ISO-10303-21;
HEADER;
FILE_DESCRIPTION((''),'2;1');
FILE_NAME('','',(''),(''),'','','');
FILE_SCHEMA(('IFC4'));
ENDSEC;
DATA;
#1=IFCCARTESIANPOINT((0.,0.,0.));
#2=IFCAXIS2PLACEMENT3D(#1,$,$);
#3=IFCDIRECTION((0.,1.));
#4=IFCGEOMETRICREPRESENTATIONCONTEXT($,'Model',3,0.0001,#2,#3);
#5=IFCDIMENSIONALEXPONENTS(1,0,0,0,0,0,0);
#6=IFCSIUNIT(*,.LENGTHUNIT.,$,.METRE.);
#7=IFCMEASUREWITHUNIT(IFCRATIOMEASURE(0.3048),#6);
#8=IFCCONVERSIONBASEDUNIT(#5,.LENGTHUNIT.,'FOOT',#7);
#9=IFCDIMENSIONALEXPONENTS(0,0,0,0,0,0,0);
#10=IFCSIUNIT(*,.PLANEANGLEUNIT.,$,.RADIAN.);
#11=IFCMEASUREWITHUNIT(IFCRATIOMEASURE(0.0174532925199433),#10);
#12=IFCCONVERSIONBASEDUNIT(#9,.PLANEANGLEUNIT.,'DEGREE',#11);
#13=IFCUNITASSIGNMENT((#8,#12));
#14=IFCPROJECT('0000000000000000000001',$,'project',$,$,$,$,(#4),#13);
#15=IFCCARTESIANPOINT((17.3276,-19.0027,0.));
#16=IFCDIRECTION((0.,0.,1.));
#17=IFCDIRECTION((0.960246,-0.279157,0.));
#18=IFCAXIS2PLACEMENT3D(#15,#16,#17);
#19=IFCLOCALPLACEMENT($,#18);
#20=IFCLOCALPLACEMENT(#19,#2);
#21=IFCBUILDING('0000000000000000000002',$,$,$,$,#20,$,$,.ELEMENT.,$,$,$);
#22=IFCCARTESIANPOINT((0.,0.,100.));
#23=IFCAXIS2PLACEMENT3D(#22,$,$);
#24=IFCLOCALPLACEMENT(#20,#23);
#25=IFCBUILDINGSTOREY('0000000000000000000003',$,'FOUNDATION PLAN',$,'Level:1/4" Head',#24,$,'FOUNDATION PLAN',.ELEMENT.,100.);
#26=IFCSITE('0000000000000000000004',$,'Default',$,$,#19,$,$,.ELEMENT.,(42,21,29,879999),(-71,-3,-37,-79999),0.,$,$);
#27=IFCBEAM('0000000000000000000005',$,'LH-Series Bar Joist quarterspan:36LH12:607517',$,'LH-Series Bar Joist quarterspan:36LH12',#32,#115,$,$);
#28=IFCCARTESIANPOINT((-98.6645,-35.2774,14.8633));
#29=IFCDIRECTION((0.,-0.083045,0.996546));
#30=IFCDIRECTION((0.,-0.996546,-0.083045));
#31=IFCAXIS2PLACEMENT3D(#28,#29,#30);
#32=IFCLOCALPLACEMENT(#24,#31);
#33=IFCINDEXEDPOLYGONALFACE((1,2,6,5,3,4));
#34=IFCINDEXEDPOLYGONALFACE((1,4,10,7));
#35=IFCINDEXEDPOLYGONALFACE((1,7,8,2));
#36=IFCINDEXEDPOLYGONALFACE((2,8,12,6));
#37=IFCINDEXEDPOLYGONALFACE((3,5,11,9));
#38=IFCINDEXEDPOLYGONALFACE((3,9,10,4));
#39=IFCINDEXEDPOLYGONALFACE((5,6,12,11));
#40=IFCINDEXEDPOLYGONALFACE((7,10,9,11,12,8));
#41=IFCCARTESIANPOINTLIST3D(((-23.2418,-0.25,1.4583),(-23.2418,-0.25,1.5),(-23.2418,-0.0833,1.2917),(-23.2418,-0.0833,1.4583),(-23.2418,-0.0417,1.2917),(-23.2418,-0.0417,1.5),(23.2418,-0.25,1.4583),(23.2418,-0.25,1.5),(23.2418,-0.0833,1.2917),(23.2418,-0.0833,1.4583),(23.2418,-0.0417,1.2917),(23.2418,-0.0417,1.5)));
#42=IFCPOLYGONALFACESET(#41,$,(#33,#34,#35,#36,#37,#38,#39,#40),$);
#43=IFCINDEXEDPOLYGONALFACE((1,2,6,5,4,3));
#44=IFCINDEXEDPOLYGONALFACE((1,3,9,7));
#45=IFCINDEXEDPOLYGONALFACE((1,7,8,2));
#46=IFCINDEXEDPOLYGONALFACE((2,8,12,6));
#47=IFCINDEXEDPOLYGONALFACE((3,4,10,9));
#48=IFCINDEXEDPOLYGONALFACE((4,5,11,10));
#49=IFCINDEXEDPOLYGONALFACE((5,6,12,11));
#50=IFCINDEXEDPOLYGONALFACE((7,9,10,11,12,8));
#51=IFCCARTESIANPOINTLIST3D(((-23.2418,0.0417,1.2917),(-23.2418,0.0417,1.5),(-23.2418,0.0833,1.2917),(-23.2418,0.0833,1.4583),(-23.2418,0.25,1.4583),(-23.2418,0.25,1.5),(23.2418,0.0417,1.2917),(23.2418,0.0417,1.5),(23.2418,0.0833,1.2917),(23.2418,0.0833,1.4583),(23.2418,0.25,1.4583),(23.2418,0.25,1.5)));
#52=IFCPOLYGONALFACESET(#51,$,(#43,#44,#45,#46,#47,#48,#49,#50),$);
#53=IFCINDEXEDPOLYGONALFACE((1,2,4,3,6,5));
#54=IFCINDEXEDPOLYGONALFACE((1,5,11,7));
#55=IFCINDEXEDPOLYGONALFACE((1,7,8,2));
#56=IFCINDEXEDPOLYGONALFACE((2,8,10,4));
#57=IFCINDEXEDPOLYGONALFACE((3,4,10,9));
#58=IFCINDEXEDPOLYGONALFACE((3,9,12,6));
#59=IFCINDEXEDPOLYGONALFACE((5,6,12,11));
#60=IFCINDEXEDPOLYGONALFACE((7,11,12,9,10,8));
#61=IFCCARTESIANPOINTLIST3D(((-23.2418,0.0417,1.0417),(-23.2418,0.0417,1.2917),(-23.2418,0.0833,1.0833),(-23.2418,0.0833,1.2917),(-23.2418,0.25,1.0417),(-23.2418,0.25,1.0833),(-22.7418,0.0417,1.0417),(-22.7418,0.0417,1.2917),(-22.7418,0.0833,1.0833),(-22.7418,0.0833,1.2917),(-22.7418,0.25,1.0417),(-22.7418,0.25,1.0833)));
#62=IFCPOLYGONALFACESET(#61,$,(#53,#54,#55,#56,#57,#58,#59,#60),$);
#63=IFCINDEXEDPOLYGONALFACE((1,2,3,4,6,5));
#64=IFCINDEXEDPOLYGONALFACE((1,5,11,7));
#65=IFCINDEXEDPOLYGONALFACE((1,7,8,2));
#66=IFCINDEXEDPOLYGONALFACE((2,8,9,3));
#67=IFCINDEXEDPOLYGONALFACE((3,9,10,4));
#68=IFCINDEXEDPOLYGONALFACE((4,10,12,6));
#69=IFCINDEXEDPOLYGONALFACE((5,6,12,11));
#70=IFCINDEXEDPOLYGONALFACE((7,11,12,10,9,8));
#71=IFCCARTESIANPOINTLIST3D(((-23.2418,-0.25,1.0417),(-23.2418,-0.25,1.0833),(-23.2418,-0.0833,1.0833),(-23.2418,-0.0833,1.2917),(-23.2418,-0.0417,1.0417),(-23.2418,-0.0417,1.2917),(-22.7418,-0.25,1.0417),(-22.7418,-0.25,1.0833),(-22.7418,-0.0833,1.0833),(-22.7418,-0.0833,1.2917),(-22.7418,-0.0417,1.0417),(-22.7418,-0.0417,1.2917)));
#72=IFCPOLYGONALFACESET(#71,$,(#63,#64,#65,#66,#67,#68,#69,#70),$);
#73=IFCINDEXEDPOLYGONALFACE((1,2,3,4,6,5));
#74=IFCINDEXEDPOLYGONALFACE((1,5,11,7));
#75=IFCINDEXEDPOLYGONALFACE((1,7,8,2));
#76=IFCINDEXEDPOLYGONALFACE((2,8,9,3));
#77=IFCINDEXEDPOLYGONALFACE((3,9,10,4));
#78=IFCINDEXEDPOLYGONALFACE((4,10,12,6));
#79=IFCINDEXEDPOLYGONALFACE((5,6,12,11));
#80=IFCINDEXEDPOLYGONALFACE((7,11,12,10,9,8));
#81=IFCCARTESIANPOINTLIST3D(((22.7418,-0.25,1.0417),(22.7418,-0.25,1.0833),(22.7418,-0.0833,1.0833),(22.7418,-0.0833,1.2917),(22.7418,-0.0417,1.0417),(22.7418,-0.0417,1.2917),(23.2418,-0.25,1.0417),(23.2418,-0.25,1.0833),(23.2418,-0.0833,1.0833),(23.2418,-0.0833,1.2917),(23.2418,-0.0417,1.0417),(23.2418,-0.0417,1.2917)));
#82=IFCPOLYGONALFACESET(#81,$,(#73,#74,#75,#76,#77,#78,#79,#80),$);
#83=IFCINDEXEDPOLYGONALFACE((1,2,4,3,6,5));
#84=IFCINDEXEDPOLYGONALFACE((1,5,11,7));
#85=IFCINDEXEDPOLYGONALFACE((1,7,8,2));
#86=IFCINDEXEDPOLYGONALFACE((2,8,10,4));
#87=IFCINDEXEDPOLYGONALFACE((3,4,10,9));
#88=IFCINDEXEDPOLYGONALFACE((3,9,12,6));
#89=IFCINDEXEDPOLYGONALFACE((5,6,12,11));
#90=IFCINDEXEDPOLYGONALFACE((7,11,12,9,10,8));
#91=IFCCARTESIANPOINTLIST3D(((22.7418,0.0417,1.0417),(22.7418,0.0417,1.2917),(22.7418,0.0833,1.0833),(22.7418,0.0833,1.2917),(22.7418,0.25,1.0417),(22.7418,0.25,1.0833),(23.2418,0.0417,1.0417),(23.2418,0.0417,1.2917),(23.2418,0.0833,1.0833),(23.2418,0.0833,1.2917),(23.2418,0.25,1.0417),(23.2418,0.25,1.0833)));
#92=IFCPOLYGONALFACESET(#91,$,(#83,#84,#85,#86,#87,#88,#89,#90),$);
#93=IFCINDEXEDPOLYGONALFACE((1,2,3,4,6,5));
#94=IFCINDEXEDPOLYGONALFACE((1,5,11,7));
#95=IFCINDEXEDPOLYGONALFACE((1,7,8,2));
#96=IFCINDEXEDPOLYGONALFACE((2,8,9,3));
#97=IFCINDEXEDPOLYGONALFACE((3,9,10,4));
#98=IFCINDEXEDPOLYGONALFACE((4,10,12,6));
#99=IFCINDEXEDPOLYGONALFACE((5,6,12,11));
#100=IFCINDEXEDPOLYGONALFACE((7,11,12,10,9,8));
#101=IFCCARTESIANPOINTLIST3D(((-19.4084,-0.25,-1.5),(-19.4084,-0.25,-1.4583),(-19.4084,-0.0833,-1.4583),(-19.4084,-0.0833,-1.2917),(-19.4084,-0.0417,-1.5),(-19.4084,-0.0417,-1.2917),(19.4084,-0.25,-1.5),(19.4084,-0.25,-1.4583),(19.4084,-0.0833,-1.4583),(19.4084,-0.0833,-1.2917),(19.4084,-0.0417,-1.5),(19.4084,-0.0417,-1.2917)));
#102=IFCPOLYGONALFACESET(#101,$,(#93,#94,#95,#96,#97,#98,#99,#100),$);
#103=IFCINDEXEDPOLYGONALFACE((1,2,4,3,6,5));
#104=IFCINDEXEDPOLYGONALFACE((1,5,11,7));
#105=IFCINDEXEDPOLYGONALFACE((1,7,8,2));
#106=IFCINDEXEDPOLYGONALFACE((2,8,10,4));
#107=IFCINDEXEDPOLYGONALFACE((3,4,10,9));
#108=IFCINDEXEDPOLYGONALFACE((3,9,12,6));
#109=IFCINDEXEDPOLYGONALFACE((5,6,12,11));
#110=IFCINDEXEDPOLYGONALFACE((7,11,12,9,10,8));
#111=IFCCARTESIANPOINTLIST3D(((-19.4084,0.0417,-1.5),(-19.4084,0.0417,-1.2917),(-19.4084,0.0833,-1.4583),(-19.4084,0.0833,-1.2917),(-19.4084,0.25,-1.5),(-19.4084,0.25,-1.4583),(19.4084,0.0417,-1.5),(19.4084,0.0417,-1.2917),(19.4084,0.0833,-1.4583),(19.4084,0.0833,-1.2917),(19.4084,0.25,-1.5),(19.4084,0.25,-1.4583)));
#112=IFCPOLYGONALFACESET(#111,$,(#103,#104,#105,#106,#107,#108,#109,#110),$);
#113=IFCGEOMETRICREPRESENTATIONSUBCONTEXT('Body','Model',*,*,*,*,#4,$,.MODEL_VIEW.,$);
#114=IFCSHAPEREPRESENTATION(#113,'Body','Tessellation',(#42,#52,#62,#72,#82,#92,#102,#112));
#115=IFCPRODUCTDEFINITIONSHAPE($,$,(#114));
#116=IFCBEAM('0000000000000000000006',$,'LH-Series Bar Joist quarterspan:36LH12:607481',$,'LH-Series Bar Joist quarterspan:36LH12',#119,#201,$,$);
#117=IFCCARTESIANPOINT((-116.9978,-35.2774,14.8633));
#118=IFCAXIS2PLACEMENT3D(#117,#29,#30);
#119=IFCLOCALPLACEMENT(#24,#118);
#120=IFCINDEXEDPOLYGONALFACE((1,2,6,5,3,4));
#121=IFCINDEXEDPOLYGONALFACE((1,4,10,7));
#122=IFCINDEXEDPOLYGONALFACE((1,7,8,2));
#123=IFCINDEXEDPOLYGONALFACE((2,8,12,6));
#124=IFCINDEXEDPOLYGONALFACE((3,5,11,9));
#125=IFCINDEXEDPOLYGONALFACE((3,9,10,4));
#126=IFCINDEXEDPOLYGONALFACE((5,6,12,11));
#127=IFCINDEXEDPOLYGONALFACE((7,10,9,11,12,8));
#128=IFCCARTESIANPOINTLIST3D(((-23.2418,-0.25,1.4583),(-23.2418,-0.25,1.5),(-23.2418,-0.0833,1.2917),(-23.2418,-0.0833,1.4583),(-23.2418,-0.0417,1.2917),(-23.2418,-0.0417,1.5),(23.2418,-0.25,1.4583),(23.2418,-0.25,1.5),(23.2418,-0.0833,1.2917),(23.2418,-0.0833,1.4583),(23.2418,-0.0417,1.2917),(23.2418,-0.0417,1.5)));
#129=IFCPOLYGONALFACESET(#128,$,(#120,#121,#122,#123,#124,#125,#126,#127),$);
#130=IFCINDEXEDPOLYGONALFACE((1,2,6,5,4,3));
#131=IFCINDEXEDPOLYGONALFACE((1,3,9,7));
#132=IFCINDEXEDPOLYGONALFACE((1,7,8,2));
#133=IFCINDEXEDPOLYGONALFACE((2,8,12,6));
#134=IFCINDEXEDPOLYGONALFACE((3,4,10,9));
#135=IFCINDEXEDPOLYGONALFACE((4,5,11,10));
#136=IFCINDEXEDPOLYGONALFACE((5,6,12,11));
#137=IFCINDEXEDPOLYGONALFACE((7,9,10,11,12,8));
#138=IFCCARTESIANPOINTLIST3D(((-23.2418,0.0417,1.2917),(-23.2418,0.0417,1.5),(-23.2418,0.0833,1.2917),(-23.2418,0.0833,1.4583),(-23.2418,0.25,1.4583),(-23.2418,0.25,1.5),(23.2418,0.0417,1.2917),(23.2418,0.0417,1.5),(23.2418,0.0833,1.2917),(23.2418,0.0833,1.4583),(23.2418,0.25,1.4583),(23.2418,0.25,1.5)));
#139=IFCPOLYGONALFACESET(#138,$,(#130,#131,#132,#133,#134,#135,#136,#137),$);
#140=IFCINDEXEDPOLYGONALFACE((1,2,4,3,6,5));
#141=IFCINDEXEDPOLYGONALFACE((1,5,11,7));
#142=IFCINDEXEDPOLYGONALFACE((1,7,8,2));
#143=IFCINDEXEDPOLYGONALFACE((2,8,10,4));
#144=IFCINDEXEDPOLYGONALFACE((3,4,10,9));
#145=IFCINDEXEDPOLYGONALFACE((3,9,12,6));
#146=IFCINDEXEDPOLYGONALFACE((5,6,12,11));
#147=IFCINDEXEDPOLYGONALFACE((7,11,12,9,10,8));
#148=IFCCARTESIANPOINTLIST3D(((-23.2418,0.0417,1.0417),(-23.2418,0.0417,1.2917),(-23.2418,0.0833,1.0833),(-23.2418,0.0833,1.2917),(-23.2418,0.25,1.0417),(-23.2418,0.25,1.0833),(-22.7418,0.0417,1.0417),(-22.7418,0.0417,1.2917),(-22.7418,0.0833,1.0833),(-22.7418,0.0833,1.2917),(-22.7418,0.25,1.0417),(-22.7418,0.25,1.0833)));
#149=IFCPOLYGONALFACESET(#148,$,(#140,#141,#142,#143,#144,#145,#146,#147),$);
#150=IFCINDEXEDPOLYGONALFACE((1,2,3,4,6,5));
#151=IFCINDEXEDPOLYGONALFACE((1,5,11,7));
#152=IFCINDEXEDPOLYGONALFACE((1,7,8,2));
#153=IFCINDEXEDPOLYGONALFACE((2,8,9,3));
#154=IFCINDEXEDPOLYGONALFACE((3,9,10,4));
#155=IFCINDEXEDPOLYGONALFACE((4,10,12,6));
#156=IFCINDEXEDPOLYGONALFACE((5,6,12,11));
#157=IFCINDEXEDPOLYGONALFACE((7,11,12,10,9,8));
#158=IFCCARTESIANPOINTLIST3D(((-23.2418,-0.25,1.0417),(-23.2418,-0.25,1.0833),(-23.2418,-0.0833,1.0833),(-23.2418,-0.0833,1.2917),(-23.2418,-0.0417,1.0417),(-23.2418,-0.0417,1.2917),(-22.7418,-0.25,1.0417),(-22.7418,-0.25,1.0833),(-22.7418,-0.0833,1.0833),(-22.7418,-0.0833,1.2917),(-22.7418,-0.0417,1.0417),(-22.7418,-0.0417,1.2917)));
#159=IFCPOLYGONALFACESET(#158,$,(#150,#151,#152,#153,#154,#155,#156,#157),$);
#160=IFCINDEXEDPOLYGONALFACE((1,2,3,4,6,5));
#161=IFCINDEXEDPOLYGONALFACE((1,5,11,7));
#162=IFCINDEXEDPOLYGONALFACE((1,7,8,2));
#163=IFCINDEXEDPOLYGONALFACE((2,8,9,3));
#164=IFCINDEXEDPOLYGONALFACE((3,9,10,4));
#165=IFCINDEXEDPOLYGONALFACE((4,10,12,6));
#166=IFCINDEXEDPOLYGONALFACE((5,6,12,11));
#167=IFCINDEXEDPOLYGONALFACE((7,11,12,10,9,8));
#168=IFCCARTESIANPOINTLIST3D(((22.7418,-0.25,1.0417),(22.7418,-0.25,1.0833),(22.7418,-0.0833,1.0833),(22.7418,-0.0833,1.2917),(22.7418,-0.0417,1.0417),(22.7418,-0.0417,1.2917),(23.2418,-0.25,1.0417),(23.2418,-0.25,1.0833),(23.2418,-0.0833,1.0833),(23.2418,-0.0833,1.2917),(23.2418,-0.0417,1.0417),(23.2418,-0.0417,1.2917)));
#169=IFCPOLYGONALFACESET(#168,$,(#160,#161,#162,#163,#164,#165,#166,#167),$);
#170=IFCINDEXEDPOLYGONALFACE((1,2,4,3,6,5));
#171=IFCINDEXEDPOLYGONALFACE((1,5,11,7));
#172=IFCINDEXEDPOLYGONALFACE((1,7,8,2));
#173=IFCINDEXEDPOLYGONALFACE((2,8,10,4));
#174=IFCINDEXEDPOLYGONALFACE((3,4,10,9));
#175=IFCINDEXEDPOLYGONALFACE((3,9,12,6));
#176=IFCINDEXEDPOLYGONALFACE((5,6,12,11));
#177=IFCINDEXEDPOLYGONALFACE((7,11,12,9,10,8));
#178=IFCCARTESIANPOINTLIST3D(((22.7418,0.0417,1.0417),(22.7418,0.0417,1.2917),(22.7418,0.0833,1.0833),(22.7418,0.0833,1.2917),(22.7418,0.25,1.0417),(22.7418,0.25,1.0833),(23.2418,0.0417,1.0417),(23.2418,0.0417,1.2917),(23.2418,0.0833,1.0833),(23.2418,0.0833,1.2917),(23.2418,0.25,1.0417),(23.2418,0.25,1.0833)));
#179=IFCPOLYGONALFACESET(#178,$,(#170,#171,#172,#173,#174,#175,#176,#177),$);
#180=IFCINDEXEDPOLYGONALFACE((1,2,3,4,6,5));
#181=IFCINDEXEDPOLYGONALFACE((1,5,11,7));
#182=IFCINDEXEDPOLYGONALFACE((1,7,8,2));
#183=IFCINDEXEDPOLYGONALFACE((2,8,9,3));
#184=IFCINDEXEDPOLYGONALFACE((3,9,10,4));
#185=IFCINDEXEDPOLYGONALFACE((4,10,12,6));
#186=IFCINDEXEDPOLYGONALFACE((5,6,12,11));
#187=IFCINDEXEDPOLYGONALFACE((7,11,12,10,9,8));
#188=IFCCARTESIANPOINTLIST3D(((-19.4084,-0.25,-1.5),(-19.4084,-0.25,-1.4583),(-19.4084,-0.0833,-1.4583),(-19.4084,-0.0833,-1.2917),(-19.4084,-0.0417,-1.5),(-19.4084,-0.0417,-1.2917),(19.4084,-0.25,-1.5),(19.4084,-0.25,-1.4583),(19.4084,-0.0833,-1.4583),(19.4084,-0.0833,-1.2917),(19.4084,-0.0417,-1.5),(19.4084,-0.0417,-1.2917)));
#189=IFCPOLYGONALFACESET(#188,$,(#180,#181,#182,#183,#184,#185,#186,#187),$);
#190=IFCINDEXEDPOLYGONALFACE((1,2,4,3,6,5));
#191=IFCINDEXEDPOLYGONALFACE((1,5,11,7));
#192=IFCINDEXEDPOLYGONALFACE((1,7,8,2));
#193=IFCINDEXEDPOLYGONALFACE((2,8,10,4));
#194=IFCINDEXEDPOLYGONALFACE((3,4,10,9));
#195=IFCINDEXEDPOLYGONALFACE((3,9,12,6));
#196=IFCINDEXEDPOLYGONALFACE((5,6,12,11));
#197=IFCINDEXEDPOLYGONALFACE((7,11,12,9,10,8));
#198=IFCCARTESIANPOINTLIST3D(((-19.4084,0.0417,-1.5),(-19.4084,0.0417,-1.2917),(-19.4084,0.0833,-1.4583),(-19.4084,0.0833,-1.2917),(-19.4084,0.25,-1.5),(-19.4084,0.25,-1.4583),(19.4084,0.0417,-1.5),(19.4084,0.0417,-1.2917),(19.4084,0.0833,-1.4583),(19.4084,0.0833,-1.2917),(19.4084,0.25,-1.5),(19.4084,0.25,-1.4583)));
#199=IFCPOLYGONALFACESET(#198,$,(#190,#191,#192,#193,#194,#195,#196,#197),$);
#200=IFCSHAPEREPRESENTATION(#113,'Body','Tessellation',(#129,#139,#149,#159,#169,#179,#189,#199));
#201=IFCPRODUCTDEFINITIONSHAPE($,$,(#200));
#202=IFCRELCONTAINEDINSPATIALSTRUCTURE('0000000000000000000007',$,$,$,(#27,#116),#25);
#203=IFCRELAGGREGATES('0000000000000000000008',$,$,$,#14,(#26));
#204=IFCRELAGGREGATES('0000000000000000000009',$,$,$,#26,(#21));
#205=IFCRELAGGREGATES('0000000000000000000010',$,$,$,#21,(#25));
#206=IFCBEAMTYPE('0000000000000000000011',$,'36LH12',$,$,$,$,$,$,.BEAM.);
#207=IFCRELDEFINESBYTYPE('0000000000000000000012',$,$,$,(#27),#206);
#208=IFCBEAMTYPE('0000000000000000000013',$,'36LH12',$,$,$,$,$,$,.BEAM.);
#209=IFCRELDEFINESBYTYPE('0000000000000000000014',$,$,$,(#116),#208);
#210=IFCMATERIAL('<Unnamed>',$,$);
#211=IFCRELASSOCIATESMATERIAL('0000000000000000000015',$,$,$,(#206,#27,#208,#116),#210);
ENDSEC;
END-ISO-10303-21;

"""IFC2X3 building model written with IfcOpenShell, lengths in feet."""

from ifc_helpers import new_model, entity, si_unit, converted_unit, direction, frame, origin, place, context, subcontext, project, spatial, polyline, outline, extrude, source, transform, mapped, material, type_object, type_shapes, element, save


model = new_model("IFC2X3")

# Units and contexts
model_context = context("Model", 3, precision=0.0001, world=origin(), true_north=direction((0.0, 1.0)))
body_context = subcontext(model_context, "Body", "Model", "MODEL_VIEW")
ifc_project = project(units=[converted_unit("LENGTHUNIT", "FOOT", entity("IfcRatioMeasure", 0.3048), si_unit("LENGTHUNIT", "METRE"), dimensions=[1, 0, 0, 0, 0, 0, 0]), converted_unit("PLANEANGLEUNIT", "DEGREE", entity("IfcRatioMeasure", 0.0174532925199433), si_unit("PLANEANGLEUNIT", "RADIAN"), dimensions=[0, 0, 0, 0, 0, 0, 0])], contexts=[model_context])

# Site, building, storey
site_placement = place(None, frame((17.3276, -19.0027, 0.0), z_axis=(0.0, 0.0, 1.0), x_axis=(0.960246, -0.279157, 0.0)))
site = spatial("IfcSite", under=ifc_project, at=site_placement, Name="Default", CompositionType="ELEMENT", RefLatitude=(42, 21, 29, 879999), RefLongitude=(-71, -3, -37, -79999), RefElevation=0.0)
building_placement = place(site_placement, origin())
building = spatial("IfcBuilding", under=site, at=building_placement, CompositionType="ELEMENT")
storey_placement = place(building_placement, frame((0.0, 0.0, 100.0)))
storey = spatial("IfcBuildingStorey", under=building, at=storey_placement, Name="FOUNDATION PLAN", ObjectType="Level:1/4\" Head", LongName="FOUNDATION PLAN", CompositionType="ELEMENT", Elevation=100.0)

# Shared definitions
ifc_material_1 = material(Name="<Unnamed>")

# Beams
beam_type_1 = type_object("IfcBeamType", Name="36LH12", PredefinedType="BEAM", material=ifc_material_1)
shared_shape_1 = source(origin(), body_context, "Body", "SweptSolid", [
    extrude(outline(polyline([(-0.0833, -0.125), (-0.0417, -0.125), (-0.0417, 0.0417), (0.125, 0.0417), (0.125, 0.0833), (-0.0833, 0.0833), (-0.0833, -0.125)])), frame((-23.2418, -0.125, 1.4167), z_axis=(1.0, 0.0, 0.0), x_axis=(0.0, 0.0, -1.0)), (0.0, 0.0, 1.0), 46.4835),
    extrude(outline(polyline([(-0.0833, -0.0833), (0.125, -0.0833), (0.125, -0.0417), (-0.0417, -0.0417), (-0.0417, 0.125), (-0.0833, 0.125), (-0.0833, -0.0833)])), frame((-23.2418, 0.125, 1.4167), z_axis=(1.0, 0.0, 0.0), x_axis=(0.0, 0.0, -1.0)), (0.0, 0.0, 1.0), 46.4835),
    extrude(outline(polyline([(-0.1528, -0.0833), (0.0972, -0.0833), (0.0972, 0.125), (0.0556, 0.125), (0.0556, -0.0417), (-0.1528, -0.0417), (-0.1528, -0.0833)])), frame((-23.2418, 0.125, 1.1389), z_axis=(1.0, 0.0, 0.0), x_axis=(0.0, 0.0, -1.0)), (0.0, 0.0, 1.0), 0.5),
    extrude(outline(polyline([(0.0556, -0.125), (0.0972, -0.125), (0.0972, 0.0833), (-0.1528, 0.0833), (-0.1528, 0.0417), (0.0556, 0.0417), (0.0556, -0.125)])), frame((-23.2418, -0.125, 1.1389), z_axis=(1.0, 0.0, 0.0), x_axis=(0.0, 0.0, -1.0)), (0.0, 0.0, 1.0), 0.5),
    extrude(outline(polyline([(0.0556, -0.125), (0.0972, -0.125), (0.0972, 0.0833), (-0.1528, 0.0833), (-0.1528, 0.0417), (0.0556, 0.0417), (0.0556, -0.125)])), frame((22.7418, -0.125, 1.1389), z_axis=(1.0, 0.0, 0.0), x_axis=(0.0, 0.0, -1.0)), (0.0, 0.0, 1.0), 0.5),
    extrude(outline(polyline([(-0.1528, -0.0833), (0.0972, -0.0833), (0.0972, 0.125), (0.0556, 0.125), (0.0556, -0.0417), (-0.1528, -0.0417), (-0.1528, -0.0833)])), frame((22.7418, 0.125, 1.1389), z_axis=(1.0, 0.0, 0.0), x_axis=(0.0, 0.0, -1.0)), (0.0, 0.0, 1.0), 0.5),
    extrude(outline(polyline([(0.0417, -0.125), (0.0833, -0.125), (0.0833, 0.0833), (-0.125, 0.0833), (-0.125, 0.0417), (0.0417, 0.0417), (0.0417, -0.125)])), frame((-19.4084, -0.125, -1.4167), z_axis=(1.0, 0.0, 0.0), x_axis=(0.0, 0.0, -1.0)), (0.0, 0.0, 1.0), 38.8169),
    extrude(outline(polyline([(-0.125, -0.0833), (0.0833, -0.0833), (0.0833, 0.125), (0.0417, 0.125), (0.0417, -0.0417), (-0.125, -0.0417), (-0.125, -0.0833)])), frame((-19.4084, 0.125, -1.4167), z_axis=(1.0, 0.0, 0.0), x_axis=(0.0, 0.0, -1.0)), (0.0, 0.0, 1.0), 38.8169),
])
type_shapes(beam_type_1, [shared_shape_1])
for number, where, z_axis, x_axis, name in (
    (1, (-98.6645, -35.2774, 14.8633), (0.0, -0.083045, 0.996546), (0.0, -0.996546, -0.083045), "LH-Series Bar Joist quarterspan:36LH12:607517"),
):
    element("IfcBeam", number, at=place(storey_placement, frame(where, z_axis=z_axis, x_axis=x_axis)), inside=storey, type_object=beam_type_1, material=ifc_material_1, Name=name, ObjectType="LH-Series Bar Joist quarterspan:36LH12", context=body_context, shape_type="MappedRepresentation", body=[
        mapped(shared_shape_1, transform((0.0, 0.0, 0.0), scale=1.0)),
    ])
beam_type_2 = type_object("IfcBeamType", Name="36LH12", PredefinedType="BEAM", material=ifc_material_1)
shared_shape_2 = source(origin(), body_context, "Body", "SweptSolid", [
    extrude(outline(polyline([(-0.0833, -0.125), (-0.0417, -0.125), (-0.0417, 0.0417), (0.125, 0.0417), (0.125, 0.0833), (-0.0833, 0.0833), (-0.0833, -0.125)])), frame((-23.2418, -0.125, 1.4167), z_axis=(1.0, 0.0, 0.0), x_axis=(0.0, 0.0, -1.0)), (0.0, 0.0, 1.0), 46.4835),
    extrude(outline(polyline([(-0.0833, -0.0833), (0.125, -0.0833), (0.125, -0.0417), (-0.0417, -0.0417), (-0.0417, 0.125), (-0.0833, 0.125), (-0.0833, -0.0833)])), frame((-23.2418, 0.125, 1.4167), z_axis=(1.0, 0.0, 0.0), x_axis=(0.0, 0.0, -1.0)), (0.0, 0.0, 1.0), 46.4835),
    extrude(outline(polyline([(-0.1528, -0.0833), (0.0972, -0.0833), (0.0972, 0.125), (0.0556, 0.125), (0.0556, -0.0417), (-0.1528, -0.0417), (-0.1528, -0.0833)])), frame((-23.2418, 0.125, 1.1389), z_axis=(1.0, 0.0, 0.0), x_axis=(0.0, 0.0, -1.0)), (0.0, 0.0, 1.0), 0.5),
    extrude(outline(polyline([(0.0556, -0.125), (0.0972, -0.125), (0.0972, 0.0833), (-0.1528, 0.0833), (-0.1528, 0.0417), (0.0556, 0.0417), (0.0556, -0.125)])), frame((-23.2418, -0.125, 1.1389), z_axis=(1.0, 0.0, 0.0), x_axis=(0.0, 0.0, -1.0)), (0.0, 0.0, 1.0), 0.5),
    extrude(outline(polyline([(0.0556, -0.125), (0.0972, -0.125), (0.0972, 0.0833), (-0.1528, 0.0833), (-0.1528, 0.0417), (0.0556, 0.0417), (0.0556, -0.125)])), frame((22.7418, -0.125, 1.1389), z_axis=(1.0, 0.0, 0.0), x_axis=(0.0, 0.0, -1.0)), (0.0, 0.0, 1.0), 0.5),
    extrude(outline(polyline([(-0.1528, -0.0833), (0.0972, -0.0833), (0.0972, 0.125), (0.0556, 0.125), (0.0556, -0.0417), (-0.1528, -0.0417), (-0.1528, -0.0833)])), frame((22.7418, 0.125, 1.1389), z_axis=(1.0, 0.0, 0.0), x_axis=(0.0, 0.0, -1.0)), (0.0, 0.0, 1.0), 0.5),
    extrude(outline(polyline([(0.0417, -0.125), (0.0833, -0.125), (0.0833, 0.0833), (-0.125, 0.0833), (-0.125, 0.0417), (0.0417, 0.0417), (0.0417, -0.125)])), frame((-19.4084, -0.125, -1.4167), z_axis=(1.0, 0.0, 0.0), x_axis=(0.0, 0.0, -1.0)), (0.0, 0.0, 1.0), 38.8169),
    extrude(outline(polyline([(-0.125, -0.0833), (0.0833, -0.0833), (0.0833, 0.125), (0.0417, 0.125), (0.0417, -0.0417), (-0.125, -0.0417), (-0.125, -0.0833)])), frame((-19.4084, 0.125, -1.4167), z_axis=(1.0, 0.0, 0.0), x_axis=(0.0, 0.0, -1.0)), (0.0, 0.0, 1.0), 38.8169),
])
type_shapes(beam_type_2, [shared_shape_2])
beam_1_placement = place(storey_placement, frame((-116.9978, -35.2774, 14.8633), z_axis=(0.0, -0.083045, 0.996546), x_axis=(0.0, -0.996546, -0.083045)))
element("IfcBeam", 2, at=beam_1_placement, inside=storey, type_object=beam_type_2, material=ifc_material_1, Name="LH-Series Bar Joist quarterspan:36LH12:607481", ObjectType="LH-Series Bar Joist quarterspan:36LH12", context=body_context, shape_type="MappedRepresentation", body=[
    mapped(shared_shape_2, transform((0.0, 0.0, 0.0), scale=1.0)),
])

save(model, "model.ifc")
